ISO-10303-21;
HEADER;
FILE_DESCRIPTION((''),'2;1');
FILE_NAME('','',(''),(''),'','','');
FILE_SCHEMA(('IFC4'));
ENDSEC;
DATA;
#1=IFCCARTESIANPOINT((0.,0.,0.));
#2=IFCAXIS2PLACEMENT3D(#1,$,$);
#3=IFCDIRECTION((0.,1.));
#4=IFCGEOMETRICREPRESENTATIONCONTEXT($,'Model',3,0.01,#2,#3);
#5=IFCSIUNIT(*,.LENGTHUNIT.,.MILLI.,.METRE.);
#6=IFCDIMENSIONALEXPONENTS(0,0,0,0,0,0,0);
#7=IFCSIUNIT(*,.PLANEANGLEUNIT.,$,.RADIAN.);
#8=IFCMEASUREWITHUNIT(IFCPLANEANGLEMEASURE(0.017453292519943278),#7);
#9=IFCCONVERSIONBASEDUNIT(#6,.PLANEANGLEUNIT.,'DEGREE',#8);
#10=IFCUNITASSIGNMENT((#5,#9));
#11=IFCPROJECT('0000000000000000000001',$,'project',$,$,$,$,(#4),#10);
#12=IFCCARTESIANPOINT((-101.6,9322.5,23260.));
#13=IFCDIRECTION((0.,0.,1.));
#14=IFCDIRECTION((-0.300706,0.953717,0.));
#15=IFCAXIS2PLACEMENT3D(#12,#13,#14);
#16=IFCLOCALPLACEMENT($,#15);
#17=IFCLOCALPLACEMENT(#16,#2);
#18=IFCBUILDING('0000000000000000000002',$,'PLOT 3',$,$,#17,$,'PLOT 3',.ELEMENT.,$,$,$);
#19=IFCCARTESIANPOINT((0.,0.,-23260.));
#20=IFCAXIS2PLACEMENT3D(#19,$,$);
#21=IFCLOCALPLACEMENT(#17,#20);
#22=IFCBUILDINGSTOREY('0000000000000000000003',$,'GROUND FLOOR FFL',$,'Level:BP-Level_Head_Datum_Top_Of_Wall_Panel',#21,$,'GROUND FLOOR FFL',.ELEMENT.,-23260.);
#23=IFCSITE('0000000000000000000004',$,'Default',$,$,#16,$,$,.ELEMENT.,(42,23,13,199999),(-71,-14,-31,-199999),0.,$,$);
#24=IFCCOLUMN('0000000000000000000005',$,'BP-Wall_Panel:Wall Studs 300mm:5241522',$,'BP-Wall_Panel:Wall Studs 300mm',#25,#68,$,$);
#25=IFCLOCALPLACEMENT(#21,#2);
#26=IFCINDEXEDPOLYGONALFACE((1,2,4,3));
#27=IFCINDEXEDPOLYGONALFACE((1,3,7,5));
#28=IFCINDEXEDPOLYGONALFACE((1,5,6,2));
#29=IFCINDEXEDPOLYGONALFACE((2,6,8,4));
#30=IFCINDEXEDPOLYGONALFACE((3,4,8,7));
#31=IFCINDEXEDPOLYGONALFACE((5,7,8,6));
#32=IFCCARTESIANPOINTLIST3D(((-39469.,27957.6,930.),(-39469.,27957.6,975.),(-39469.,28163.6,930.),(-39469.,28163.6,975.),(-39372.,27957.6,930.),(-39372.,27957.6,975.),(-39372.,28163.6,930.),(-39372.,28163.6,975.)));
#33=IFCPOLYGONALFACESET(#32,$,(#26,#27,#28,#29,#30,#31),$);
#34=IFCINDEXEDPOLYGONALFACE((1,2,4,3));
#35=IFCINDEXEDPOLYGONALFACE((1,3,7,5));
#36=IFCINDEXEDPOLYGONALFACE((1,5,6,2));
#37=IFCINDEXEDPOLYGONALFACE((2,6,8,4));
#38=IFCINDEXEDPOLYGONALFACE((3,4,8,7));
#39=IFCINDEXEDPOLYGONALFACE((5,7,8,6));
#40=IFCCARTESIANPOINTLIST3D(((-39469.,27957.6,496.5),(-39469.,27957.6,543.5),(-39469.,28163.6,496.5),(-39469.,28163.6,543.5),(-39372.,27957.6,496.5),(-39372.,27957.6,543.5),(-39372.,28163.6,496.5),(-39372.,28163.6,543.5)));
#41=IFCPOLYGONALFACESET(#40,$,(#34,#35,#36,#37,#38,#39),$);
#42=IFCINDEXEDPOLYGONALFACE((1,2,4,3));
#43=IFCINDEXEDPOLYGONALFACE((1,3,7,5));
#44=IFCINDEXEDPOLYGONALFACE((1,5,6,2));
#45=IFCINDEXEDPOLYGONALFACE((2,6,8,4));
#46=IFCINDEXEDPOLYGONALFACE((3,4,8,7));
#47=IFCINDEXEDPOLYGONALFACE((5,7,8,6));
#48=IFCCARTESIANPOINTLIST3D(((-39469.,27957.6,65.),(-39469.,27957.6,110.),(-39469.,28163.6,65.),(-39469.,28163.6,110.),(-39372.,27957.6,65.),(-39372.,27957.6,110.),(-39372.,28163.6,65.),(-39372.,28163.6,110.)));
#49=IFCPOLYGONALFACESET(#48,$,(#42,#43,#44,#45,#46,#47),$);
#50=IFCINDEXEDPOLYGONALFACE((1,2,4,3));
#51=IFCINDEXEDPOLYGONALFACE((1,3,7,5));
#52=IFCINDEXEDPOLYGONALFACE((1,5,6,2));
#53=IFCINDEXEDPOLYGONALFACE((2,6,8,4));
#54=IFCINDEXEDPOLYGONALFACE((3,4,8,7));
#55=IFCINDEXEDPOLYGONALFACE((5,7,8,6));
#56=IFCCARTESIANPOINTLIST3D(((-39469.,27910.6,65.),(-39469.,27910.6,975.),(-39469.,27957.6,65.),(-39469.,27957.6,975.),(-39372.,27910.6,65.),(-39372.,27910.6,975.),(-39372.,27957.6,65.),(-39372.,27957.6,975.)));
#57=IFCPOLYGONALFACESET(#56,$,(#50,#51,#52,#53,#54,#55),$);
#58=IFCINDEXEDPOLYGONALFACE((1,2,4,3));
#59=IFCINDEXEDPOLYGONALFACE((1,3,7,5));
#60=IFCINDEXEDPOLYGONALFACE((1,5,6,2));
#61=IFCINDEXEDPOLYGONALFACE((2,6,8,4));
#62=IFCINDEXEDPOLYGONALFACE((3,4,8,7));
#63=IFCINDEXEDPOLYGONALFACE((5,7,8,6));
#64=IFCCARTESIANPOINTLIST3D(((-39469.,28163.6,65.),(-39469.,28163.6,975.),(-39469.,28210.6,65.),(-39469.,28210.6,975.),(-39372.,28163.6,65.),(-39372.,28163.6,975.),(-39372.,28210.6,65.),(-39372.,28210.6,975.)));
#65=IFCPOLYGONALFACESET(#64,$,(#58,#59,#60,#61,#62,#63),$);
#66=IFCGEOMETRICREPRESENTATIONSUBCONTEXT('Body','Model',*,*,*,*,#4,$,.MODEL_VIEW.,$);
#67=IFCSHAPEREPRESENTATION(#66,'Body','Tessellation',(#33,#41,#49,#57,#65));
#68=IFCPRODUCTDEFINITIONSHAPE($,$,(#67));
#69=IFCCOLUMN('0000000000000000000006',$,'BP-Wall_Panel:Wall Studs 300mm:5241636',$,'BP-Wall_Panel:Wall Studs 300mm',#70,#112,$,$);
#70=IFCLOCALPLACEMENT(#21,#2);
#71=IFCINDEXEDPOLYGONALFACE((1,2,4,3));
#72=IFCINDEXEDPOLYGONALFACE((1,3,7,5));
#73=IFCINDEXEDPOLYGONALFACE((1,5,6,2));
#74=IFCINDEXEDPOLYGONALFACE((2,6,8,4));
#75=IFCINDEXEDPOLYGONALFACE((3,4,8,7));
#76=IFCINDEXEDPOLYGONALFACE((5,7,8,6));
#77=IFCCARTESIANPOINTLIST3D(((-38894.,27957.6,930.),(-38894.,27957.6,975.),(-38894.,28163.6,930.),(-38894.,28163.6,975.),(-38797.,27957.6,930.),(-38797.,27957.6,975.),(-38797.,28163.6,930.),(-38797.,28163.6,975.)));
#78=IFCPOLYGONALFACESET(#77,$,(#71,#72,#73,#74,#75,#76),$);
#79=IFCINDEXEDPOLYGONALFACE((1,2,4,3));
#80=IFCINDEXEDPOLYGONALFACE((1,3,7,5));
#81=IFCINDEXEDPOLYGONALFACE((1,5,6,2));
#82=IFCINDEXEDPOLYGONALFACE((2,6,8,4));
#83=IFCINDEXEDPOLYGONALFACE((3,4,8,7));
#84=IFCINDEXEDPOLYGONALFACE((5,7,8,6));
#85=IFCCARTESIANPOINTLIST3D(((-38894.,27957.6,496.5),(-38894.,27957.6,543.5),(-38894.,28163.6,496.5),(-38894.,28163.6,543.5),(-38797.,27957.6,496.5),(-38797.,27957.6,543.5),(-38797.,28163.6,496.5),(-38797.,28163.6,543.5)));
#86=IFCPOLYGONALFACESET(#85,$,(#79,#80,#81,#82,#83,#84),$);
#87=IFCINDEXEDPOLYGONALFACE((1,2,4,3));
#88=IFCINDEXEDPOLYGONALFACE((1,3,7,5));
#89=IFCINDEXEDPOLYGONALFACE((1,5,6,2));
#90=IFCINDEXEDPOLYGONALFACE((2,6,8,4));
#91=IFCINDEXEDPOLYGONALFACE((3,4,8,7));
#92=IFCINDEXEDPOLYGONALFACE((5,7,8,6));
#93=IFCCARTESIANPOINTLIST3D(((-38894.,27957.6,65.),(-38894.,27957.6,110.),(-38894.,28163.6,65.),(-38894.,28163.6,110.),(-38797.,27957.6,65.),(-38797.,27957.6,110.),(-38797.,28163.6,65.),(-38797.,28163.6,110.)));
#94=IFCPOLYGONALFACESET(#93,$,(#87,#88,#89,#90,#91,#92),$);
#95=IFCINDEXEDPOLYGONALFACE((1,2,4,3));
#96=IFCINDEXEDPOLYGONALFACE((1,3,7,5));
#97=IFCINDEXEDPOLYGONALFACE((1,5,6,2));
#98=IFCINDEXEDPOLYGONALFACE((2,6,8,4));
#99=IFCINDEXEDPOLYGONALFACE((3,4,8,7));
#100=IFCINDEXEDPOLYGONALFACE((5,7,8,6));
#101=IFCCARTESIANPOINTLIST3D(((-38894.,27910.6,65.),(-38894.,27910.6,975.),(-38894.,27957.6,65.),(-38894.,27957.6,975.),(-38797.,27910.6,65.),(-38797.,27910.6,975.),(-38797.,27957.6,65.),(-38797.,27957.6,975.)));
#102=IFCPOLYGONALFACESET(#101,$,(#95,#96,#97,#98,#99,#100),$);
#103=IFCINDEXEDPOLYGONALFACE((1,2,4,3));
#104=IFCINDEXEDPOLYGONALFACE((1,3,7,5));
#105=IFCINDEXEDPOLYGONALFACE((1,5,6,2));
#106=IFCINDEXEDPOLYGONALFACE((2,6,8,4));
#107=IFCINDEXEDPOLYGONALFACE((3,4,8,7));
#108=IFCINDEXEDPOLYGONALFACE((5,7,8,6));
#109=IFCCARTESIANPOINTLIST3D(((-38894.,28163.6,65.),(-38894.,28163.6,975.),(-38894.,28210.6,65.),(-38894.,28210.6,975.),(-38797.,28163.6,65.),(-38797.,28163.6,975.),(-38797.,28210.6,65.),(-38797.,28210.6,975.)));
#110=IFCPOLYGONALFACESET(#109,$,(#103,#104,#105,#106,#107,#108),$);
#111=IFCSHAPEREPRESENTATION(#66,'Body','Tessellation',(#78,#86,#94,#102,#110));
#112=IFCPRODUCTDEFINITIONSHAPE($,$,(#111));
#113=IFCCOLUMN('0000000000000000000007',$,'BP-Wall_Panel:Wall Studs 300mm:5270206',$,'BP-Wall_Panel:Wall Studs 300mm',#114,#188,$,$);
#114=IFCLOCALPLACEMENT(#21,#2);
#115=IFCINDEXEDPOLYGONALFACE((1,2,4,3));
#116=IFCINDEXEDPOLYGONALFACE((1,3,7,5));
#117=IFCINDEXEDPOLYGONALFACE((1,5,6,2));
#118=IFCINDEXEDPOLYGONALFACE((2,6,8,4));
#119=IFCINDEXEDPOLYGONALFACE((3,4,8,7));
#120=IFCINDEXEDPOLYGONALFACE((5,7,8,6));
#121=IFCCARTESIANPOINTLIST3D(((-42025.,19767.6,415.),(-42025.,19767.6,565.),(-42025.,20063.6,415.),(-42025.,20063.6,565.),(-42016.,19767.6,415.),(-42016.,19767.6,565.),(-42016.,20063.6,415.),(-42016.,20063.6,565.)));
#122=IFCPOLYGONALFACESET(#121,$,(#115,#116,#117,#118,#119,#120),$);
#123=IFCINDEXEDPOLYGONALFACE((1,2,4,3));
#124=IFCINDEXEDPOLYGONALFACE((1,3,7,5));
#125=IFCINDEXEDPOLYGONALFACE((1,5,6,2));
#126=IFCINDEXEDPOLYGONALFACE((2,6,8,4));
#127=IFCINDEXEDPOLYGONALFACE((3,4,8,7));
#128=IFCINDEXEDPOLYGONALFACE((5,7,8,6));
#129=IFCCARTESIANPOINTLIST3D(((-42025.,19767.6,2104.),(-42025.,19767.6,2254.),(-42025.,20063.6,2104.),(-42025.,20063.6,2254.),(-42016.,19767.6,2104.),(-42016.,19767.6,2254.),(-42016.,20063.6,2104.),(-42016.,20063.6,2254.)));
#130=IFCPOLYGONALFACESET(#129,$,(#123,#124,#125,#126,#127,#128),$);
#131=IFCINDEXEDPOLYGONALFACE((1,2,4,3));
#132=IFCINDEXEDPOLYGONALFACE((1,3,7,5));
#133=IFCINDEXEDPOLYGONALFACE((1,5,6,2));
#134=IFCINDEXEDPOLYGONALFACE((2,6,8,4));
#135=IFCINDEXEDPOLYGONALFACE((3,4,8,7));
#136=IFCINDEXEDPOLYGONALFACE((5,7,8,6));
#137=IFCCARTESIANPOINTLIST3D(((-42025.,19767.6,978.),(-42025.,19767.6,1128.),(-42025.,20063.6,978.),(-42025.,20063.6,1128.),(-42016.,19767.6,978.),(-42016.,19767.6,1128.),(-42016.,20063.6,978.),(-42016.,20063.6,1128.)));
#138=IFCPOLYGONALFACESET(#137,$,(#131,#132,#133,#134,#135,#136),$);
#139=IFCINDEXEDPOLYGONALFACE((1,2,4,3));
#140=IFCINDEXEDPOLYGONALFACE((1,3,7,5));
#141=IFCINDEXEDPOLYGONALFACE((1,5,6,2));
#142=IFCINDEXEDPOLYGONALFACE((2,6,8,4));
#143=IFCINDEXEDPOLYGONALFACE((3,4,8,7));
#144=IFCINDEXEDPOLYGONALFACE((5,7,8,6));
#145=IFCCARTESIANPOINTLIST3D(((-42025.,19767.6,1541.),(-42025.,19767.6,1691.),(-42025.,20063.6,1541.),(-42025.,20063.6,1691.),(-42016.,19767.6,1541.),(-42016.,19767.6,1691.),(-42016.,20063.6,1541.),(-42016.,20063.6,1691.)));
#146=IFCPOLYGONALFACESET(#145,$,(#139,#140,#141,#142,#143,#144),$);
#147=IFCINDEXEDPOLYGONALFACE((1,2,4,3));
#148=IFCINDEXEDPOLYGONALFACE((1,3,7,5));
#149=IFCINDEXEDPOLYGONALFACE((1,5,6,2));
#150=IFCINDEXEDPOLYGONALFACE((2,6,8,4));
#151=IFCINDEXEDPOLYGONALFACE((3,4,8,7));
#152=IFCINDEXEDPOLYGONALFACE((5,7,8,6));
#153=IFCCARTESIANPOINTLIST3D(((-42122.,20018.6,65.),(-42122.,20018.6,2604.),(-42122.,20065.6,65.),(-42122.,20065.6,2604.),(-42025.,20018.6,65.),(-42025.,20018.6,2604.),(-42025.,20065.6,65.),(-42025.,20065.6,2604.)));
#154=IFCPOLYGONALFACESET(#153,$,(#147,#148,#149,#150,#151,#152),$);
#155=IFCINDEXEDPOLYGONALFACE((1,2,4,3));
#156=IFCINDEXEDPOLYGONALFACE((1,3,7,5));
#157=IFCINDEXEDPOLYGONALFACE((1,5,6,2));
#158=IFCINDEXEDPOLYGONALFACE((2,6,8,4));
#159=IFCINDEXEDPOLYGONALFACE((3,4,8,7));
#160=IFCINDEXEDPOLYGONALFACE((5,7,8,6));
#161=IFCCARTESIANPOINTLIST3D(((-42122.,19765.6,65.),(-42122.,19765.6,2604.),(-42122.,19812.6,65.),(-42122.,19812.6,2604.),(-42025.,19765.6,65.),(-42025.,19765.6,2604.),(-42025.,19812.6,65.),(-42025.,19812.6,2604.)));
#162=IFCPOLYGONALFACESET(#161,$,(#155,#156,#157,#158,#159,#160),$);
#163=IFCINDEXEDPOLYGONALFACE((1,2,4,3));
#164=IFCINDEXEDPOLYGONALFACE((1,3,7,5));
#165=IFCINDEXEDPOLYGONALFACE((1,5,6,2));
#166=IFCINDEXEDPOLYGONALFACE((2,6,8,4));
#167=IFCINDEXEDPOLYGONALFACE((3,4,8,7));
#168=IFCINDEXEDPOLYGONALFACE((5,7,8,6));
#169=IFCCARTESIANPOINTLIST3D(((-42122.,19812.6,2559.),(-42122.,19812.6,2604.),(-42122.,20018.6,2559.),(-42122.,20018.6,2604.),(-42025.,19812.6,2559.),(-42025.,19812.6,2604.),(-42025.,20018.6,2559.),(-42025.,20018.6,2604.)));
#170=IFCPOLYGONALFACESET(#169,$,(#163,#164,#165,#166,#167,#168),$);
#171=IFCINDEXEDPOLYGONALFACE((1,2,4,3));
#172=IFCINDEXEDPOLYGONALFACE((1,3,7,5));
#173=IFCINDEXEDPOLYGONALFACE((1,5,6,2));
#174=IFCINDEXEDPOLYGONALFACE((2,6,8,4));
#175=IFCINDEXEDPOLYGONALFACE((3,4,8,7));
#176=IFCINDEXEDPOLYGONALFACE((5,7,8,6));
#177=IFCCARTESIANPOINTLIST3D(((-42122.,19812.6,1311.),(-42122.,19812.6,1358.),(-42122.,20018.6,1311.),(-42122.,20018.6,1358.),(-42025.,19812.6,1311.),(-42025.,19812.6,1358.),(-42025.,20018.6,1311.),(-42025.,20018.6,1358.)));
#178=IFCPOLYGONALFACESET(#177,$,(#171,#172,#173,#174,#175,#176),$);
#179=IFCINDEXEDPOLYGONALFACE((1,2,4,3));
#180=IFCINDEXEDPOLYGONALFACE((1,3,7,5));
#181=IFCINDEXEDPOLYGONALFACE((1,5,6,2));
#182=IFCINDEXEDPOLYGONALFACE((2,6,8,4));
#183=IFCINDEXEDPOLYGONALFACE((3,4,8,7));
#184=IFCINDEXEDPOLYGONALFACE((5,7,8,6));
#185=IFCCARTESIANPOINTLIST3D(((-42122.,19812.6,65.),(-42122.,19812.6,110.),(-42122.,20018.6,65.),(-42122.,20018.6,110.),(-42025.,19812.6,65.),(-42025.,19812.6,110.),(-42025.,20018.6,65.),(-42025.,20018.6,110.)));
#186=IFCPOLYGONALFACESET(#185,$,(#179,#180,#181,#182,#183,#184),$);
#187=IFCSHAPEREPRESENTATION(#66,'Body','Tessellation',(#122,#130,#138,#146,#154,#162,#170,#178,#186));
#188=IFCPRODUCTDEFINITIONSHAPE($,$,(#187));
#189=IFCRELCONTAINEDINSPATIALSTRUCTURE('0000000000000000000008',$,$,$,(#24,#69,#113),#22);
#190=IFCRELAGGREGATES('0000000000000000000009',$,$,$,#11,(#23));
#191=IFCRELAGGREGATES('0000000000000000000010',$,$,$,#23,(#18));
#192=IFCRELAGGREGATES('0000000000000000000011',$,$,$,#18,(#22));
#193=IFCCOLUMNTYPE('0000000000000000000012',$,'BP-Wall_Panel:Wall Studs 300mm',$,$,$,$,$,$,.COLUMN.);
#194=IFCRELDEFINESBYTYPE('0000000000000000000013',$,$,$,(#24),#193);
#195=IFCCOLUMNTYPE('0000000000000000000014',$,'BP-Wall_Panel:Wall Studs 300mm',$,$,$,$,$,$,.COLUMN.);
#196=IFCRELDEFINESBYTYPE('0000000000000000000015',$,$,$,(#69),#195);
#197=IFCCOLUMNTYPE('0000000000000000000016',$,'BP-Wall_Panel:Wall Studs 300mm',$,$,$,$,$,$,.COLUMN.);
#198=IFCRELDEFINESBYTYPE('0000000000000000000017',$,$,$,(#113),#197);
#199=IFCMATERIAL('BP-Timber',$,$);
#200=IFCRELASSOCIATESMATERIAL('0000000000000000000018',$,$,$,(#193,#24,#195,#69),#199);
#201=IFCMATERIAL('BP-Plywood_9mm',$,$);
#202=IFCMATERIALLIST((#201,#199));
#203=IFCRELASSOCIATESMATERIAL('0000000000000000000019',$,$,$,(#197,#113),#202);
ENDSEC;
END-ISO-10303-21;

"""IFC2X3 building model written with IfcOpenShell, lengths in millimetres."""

from ifc_helpers import new_model, entity, si_unit, converted_unit, direction, frame, frame_2d, origin, origin_2d_with_axis, place, context, subcontext, project, spatial, rectangle, extrude, source, transform, mapped, material, material_list, type_object, type_shapes, element, save


model = new_model("IFC2X3")

# Units and contexts
model_context = context("Model", 3, precision=0.01, world=origin(), true_north=direction((0.0, 1.0)))
body_context = subcontext(model_context, "Body", "Model", "MODEL_VIEW")
ifc_project = project(units=[si_unit("LENGTHUNIT", "METRE", prefix="MILLI"), converted_unit("PLANEANGLEUNIT", "DEGREE", entity("IfcPlaneAngleMeasure", 0.017453292519943278), si_unit("PLANEANGLEUNIT", "RADIAN"), dimensions=[0, 0, 0, 0, 0, 0, 0])], contexts=[model_context])

# Site, building, storey
site_placement = place(None, frame((-101.6, 9322.5, 23260.0), z_axis=(0.0, 0.0, 1.0), x_axis=(-0.300706, 0.953717, 0.0)))
site = spatial("IfcSite", under=ifc_project, at=site_placement, Name="Default", CompositionType="ELEMENT", RefLatitude=(42, 23, 13, 199999), RefLongitude=(-71, -14, -31, -199999), RefElevation=0.0)
building_placement = place(site_placement, origin())
building = spatial("IfcBuilding", under=site, at=building_placement, Name="PLOT 3", LongName="PLOT 3", CompositionType="ELEMENT")
storey_placement = place(building_placement, frame((0.0, 0.0, -23260.0)))
storey = spatial("IfcBuildingStorey", under=building, at=storey_placement, Name="GROUND FLOOR FFL", ObjectType="Level:BP-Level_Head_Datum_Top_Of_Wall_Panel", LongName="GROUND FLOOR FFL", CompositionType="ELEMENT", Elevation=-23260.0)

# Columns
ifc_material_1 = material(Name="BP-Timber")
column_type_1 = type_object("IfcColumnType", Name="BP-Wall_Panel:Wall Studs 300mm", PredefinedType="COLUMN", material=ifc_material_1)
shared_shape_1 = source(origin(), body_context, "Body", "SweptSolid", [
    extrude(rectangle(XDim=97.0, YDim=206.0, at=frame_2d((0.0, 0.0), x_axis=(1.0, 0.0))), frame((-39420.5, 28060.6, -22330.0)), (0.0, 0.0, 1.0), 45.0),
    extrude(rectangle(XDim=97.0, YDim=206.0, at=frame_2d((0.0, 0.0), x_axis=(1.0, 0.0))), frame((-39420.5, 28060.6, -22763.5)), (0.0, 0.0, 1.0), 47.0),
    extrude(rectangle(XDim=97.0, YDim=206.0, at=frame_2d((0.0, 0.0), x_axis=(1.0, 0.0))), frame((-39420.5, 28060.6, -23195.0)), (0.0, 0.0, 1.0), 45.0),
    extrude(rectangle(XDim=47.0, YDim=97.0, at=frame_2d((0.0, 0.0), x_axis=(1.0, 0.0))), frame((-39420.5, 27934.1, -23195.0), z_axis=(0.0, 0.0, 1.0), x_axis=(0.0, 1.0, 0.0)), (0.0, 0.0, 1.0), 910.0),
    extrude(rectangle(XDim=47.0, YDim=97.0, at=frame_2d((0.0, 0.0), x_axis=(1.0, 0.0))), frame((-39420.5, 28187.1, -23195.0), z_axis=(0.0, 0.0, 1.0), x_axis=(0.0, 1.0, 0.0)), (0.0, 0.0, 1.0), 910.0),
])
type_shapes(column_type_1, [shared_shape_1])
column_1_placement = place(storey_placement, frame((0.0, 0.0, 23260.0)))
element("IfcColumn", 1, at=column_1_placement, inside=storey, type_object=column_type_1, material=ifc_material_1, Name="BP-Wall_Panel:Wall Studs 300mm:5241522", ObjectType="BP-Wall_Panel:Wall Studs 300mm", context=body_context, shape_type="MappedRepresentation", body=[
    mapped(shared_shape_1, transform((0.0, 0.0, 0.0), scale=1.0)),
])
column_type_2 = type_object("IfcColumnType", Name="BP-Wall_Panel:Wall Studs 300mm", PredefinedType="COLUMN", material=ifc_material_1)
shared_shape_2 = source(origin(), body_context, "Body", "SweptSolid", [
    extrude(rectangle(XDim=97.0, YDim=206.0, at=frame_2d((0.0, 0.0), x_axis=(1.0, 0.0))), frame((-38845.5, 28060.6, -22330.0)), (0.0, 0.0, 1.0), 45.0),
    extrude(rectangle(XDim=97.0, YDim=206.0, at=frame_2d((0.0, 0.0), x_axis=(1.0, 0.0))), frame((-38845.5, 28060.6, -22763.5)), (0.0, 0.0, 1.0), 47.0),
    extrude(rectangle(XDim=97.0, YDim=206.0, at=frame_2d((0.0, 0.0), x_axis=(1.0, 0.0))), frame((-38845.5, 28060.6, -23195.0)), (0.0, 0.0, 1.0), 45.0),
    extrude(rectangle(XDim=47.0, YDim=97.0, at=frame_2d((0.0, 0.0), x_axis=(1.0, 0.0))), frame((-38845.5, 27934.1, -23195.0), z_axis=(0.0, 0.0, 1.0), x_axis=(0.0, 1.0, 0.0)), (0.0, 0.0, 1.0), 910.0),
    extrude(rectangle(XDim=47.0, YDim=97.0, at=frame_2d((0.0, 0.0), x_axis=(1.0, 0.0))), frame((-38845.5, 28187.1, -23195.0), z_axis=(0.0, 0.0, 1.0), x_axis=(0.0, 1.0, 0.0)), (0.0, 0.0, 1.0), 910.0),
])
type_shapes(column_type_2, [shared_shape_2])
column_2_placement = place(storey_placement, frame((0.0, 0.0, 23260.0)))
element("IfcColumn", 2, at=column_2_placement, inside=storey, type_object=column_type_2, material=ifc_material_1, Name="BP-Wall_Panel:Wall Studs 300mm:5241636", ObjectType="BP-Wall_Panel:Wall Studs 300mm", context=body_context, shape_type="MappedRepresentation", body=[
    mapped(shared_shape_2, transform((0.0, 0.0, 0.0), scale=1.0)),
])
ifc_material_2 = material(Name="BP-Plywood_9mm")
ifc_material_list_1 = material_list([ifc_material_2, ifc_material_1])
column_type_3 = type_object("IfcColumnType", Name="BP-Wall_Panel:Wall Studs 300mm", PredefinedType="COLUMN", material=ifc_material_list_1)
shared_shape_3 = source(origin(), body_context, "Body", "SweptSolid", [
    extrude(rectangle(XDim=296.0, YDim=9.0, at=origin_2d_with_axis()), frame((-42020.5, 19915.6, -22845.0), z_axis=(0.0, 0.0, 1.0), x_axis=(0.0, -1.0, 0.0)), (0.0, 0.0, 1.0), 150.0),
    extrude(rectangle(XDim=296.0, YDim=9.0, at=origin_2d_with_axis()), frame((-42020.5, 19915.6, -21156.0), z_axis=(0.0, 0.0, 1.0), x_axis=(0.0, -1.0, 0.0)), (0.0, 0.0, 1.0), 150.0),
    extrude(rectangle(XDim=296.0, YDim=9.0, at=origin_2d_with_axis()), frame((-42020.5, 19915.6, -22282.0), z_axis=(0.0, 0.0, 1.0), x_axis=(0.0, -1.0, 0.0)), (0.0, 0.0, 1.0), 150.0),
    extrude(rectangle(XDim=296.0, YDim=9.0, at=origin_2d_with_axis()), frame((-42020.5, 19915.6, -21719.0), z_axis=(0.0, 0.0, 1.0), x_axis=(0.0, -1.0, 0.0)), (0.0, 0.0, 1.0), 150.0),
    extrude(rectangle(XDim=47.0, YDim=97.0, at=frame_2d((0.0, 0.0), x_axis=(1.0, 0.0))), frame((-42073.5, 20042.1, -23195.0), z_axis=(0.0, 0.0, 1.0), x_axis=(0.0, -1.0, 0.0)), (0.0, 0.0, 1.0), 2539.0),
    extrude(rectangle(XDim=47.0, YDim=97.0, at=frame_2d((0.0, 0.0), x_axis=(1.0, 0.0))), frame((-42073.5, 19789.1, -23195.0), z_axis=(0.0, 0.0, 1.0), x_axis=(0.0, -1.0, 0.0)), (0.0, 0.0, 1.0), 2539.0),
    extrude(rectangle(XDim=97.0, YDim=206.0, at=frame_2d((0.0, 0.0), x_axis=(1.0, 0.0))), frame((-42073.5, 19915.6, -20701.0), z_axis=(0.0, 0.0, 1.0), x_axis=(-1.0, 0.0, 0.0)), (0.0, 0.0, 1.0), 45.0),
    extrude(rectangle(XDim=97.0, YDim=206.0, at=frame_2d((0.0, 0.0), x_axis=(1.0, 0.0))), frame((-42073.5, 19915.6, -21949.0), z_axis=(0.0, 0.0, 1.0), x_axis=(-1.0, 0.0, 0.0)), (0.0, 0.0, 1.0), 47.0),
    extrude(rectangle(XDim=97.0, YDim=206.0, at=frame_2d((0.0, 0.0), x_axis=(1.0, 0.0))), frame((-42073.5, 19915.6, -23195.0), z_axis=(0.0, 0.0, 1.0), x_axis=(-1.0, 0.0, 0.0)), (0.0, 0.0, 1.0), 45.0),
])
type_shapes(column_type_3, [shared_shape_3])
column_3_placement = place(storey_placement, frame((0.0, 0.0, 23260.0)))
element("IfcColumn", 3, at=column_3_placement, inside=storey, type_object=column_type_3, material=ifc_material_list_1, Name="BP-Wall_Panel:Wall Studs 300mm:5270206", ObjectType="BP-Wall_Panel:Wall Studs 300mm", context=body_context, shape_type="MappedRepresentation", body=[
    mapped(shared_shape_3, transform((0.0, 0.0, 0.0), scale=1.0)),
])

save(model, "model.ifc")
